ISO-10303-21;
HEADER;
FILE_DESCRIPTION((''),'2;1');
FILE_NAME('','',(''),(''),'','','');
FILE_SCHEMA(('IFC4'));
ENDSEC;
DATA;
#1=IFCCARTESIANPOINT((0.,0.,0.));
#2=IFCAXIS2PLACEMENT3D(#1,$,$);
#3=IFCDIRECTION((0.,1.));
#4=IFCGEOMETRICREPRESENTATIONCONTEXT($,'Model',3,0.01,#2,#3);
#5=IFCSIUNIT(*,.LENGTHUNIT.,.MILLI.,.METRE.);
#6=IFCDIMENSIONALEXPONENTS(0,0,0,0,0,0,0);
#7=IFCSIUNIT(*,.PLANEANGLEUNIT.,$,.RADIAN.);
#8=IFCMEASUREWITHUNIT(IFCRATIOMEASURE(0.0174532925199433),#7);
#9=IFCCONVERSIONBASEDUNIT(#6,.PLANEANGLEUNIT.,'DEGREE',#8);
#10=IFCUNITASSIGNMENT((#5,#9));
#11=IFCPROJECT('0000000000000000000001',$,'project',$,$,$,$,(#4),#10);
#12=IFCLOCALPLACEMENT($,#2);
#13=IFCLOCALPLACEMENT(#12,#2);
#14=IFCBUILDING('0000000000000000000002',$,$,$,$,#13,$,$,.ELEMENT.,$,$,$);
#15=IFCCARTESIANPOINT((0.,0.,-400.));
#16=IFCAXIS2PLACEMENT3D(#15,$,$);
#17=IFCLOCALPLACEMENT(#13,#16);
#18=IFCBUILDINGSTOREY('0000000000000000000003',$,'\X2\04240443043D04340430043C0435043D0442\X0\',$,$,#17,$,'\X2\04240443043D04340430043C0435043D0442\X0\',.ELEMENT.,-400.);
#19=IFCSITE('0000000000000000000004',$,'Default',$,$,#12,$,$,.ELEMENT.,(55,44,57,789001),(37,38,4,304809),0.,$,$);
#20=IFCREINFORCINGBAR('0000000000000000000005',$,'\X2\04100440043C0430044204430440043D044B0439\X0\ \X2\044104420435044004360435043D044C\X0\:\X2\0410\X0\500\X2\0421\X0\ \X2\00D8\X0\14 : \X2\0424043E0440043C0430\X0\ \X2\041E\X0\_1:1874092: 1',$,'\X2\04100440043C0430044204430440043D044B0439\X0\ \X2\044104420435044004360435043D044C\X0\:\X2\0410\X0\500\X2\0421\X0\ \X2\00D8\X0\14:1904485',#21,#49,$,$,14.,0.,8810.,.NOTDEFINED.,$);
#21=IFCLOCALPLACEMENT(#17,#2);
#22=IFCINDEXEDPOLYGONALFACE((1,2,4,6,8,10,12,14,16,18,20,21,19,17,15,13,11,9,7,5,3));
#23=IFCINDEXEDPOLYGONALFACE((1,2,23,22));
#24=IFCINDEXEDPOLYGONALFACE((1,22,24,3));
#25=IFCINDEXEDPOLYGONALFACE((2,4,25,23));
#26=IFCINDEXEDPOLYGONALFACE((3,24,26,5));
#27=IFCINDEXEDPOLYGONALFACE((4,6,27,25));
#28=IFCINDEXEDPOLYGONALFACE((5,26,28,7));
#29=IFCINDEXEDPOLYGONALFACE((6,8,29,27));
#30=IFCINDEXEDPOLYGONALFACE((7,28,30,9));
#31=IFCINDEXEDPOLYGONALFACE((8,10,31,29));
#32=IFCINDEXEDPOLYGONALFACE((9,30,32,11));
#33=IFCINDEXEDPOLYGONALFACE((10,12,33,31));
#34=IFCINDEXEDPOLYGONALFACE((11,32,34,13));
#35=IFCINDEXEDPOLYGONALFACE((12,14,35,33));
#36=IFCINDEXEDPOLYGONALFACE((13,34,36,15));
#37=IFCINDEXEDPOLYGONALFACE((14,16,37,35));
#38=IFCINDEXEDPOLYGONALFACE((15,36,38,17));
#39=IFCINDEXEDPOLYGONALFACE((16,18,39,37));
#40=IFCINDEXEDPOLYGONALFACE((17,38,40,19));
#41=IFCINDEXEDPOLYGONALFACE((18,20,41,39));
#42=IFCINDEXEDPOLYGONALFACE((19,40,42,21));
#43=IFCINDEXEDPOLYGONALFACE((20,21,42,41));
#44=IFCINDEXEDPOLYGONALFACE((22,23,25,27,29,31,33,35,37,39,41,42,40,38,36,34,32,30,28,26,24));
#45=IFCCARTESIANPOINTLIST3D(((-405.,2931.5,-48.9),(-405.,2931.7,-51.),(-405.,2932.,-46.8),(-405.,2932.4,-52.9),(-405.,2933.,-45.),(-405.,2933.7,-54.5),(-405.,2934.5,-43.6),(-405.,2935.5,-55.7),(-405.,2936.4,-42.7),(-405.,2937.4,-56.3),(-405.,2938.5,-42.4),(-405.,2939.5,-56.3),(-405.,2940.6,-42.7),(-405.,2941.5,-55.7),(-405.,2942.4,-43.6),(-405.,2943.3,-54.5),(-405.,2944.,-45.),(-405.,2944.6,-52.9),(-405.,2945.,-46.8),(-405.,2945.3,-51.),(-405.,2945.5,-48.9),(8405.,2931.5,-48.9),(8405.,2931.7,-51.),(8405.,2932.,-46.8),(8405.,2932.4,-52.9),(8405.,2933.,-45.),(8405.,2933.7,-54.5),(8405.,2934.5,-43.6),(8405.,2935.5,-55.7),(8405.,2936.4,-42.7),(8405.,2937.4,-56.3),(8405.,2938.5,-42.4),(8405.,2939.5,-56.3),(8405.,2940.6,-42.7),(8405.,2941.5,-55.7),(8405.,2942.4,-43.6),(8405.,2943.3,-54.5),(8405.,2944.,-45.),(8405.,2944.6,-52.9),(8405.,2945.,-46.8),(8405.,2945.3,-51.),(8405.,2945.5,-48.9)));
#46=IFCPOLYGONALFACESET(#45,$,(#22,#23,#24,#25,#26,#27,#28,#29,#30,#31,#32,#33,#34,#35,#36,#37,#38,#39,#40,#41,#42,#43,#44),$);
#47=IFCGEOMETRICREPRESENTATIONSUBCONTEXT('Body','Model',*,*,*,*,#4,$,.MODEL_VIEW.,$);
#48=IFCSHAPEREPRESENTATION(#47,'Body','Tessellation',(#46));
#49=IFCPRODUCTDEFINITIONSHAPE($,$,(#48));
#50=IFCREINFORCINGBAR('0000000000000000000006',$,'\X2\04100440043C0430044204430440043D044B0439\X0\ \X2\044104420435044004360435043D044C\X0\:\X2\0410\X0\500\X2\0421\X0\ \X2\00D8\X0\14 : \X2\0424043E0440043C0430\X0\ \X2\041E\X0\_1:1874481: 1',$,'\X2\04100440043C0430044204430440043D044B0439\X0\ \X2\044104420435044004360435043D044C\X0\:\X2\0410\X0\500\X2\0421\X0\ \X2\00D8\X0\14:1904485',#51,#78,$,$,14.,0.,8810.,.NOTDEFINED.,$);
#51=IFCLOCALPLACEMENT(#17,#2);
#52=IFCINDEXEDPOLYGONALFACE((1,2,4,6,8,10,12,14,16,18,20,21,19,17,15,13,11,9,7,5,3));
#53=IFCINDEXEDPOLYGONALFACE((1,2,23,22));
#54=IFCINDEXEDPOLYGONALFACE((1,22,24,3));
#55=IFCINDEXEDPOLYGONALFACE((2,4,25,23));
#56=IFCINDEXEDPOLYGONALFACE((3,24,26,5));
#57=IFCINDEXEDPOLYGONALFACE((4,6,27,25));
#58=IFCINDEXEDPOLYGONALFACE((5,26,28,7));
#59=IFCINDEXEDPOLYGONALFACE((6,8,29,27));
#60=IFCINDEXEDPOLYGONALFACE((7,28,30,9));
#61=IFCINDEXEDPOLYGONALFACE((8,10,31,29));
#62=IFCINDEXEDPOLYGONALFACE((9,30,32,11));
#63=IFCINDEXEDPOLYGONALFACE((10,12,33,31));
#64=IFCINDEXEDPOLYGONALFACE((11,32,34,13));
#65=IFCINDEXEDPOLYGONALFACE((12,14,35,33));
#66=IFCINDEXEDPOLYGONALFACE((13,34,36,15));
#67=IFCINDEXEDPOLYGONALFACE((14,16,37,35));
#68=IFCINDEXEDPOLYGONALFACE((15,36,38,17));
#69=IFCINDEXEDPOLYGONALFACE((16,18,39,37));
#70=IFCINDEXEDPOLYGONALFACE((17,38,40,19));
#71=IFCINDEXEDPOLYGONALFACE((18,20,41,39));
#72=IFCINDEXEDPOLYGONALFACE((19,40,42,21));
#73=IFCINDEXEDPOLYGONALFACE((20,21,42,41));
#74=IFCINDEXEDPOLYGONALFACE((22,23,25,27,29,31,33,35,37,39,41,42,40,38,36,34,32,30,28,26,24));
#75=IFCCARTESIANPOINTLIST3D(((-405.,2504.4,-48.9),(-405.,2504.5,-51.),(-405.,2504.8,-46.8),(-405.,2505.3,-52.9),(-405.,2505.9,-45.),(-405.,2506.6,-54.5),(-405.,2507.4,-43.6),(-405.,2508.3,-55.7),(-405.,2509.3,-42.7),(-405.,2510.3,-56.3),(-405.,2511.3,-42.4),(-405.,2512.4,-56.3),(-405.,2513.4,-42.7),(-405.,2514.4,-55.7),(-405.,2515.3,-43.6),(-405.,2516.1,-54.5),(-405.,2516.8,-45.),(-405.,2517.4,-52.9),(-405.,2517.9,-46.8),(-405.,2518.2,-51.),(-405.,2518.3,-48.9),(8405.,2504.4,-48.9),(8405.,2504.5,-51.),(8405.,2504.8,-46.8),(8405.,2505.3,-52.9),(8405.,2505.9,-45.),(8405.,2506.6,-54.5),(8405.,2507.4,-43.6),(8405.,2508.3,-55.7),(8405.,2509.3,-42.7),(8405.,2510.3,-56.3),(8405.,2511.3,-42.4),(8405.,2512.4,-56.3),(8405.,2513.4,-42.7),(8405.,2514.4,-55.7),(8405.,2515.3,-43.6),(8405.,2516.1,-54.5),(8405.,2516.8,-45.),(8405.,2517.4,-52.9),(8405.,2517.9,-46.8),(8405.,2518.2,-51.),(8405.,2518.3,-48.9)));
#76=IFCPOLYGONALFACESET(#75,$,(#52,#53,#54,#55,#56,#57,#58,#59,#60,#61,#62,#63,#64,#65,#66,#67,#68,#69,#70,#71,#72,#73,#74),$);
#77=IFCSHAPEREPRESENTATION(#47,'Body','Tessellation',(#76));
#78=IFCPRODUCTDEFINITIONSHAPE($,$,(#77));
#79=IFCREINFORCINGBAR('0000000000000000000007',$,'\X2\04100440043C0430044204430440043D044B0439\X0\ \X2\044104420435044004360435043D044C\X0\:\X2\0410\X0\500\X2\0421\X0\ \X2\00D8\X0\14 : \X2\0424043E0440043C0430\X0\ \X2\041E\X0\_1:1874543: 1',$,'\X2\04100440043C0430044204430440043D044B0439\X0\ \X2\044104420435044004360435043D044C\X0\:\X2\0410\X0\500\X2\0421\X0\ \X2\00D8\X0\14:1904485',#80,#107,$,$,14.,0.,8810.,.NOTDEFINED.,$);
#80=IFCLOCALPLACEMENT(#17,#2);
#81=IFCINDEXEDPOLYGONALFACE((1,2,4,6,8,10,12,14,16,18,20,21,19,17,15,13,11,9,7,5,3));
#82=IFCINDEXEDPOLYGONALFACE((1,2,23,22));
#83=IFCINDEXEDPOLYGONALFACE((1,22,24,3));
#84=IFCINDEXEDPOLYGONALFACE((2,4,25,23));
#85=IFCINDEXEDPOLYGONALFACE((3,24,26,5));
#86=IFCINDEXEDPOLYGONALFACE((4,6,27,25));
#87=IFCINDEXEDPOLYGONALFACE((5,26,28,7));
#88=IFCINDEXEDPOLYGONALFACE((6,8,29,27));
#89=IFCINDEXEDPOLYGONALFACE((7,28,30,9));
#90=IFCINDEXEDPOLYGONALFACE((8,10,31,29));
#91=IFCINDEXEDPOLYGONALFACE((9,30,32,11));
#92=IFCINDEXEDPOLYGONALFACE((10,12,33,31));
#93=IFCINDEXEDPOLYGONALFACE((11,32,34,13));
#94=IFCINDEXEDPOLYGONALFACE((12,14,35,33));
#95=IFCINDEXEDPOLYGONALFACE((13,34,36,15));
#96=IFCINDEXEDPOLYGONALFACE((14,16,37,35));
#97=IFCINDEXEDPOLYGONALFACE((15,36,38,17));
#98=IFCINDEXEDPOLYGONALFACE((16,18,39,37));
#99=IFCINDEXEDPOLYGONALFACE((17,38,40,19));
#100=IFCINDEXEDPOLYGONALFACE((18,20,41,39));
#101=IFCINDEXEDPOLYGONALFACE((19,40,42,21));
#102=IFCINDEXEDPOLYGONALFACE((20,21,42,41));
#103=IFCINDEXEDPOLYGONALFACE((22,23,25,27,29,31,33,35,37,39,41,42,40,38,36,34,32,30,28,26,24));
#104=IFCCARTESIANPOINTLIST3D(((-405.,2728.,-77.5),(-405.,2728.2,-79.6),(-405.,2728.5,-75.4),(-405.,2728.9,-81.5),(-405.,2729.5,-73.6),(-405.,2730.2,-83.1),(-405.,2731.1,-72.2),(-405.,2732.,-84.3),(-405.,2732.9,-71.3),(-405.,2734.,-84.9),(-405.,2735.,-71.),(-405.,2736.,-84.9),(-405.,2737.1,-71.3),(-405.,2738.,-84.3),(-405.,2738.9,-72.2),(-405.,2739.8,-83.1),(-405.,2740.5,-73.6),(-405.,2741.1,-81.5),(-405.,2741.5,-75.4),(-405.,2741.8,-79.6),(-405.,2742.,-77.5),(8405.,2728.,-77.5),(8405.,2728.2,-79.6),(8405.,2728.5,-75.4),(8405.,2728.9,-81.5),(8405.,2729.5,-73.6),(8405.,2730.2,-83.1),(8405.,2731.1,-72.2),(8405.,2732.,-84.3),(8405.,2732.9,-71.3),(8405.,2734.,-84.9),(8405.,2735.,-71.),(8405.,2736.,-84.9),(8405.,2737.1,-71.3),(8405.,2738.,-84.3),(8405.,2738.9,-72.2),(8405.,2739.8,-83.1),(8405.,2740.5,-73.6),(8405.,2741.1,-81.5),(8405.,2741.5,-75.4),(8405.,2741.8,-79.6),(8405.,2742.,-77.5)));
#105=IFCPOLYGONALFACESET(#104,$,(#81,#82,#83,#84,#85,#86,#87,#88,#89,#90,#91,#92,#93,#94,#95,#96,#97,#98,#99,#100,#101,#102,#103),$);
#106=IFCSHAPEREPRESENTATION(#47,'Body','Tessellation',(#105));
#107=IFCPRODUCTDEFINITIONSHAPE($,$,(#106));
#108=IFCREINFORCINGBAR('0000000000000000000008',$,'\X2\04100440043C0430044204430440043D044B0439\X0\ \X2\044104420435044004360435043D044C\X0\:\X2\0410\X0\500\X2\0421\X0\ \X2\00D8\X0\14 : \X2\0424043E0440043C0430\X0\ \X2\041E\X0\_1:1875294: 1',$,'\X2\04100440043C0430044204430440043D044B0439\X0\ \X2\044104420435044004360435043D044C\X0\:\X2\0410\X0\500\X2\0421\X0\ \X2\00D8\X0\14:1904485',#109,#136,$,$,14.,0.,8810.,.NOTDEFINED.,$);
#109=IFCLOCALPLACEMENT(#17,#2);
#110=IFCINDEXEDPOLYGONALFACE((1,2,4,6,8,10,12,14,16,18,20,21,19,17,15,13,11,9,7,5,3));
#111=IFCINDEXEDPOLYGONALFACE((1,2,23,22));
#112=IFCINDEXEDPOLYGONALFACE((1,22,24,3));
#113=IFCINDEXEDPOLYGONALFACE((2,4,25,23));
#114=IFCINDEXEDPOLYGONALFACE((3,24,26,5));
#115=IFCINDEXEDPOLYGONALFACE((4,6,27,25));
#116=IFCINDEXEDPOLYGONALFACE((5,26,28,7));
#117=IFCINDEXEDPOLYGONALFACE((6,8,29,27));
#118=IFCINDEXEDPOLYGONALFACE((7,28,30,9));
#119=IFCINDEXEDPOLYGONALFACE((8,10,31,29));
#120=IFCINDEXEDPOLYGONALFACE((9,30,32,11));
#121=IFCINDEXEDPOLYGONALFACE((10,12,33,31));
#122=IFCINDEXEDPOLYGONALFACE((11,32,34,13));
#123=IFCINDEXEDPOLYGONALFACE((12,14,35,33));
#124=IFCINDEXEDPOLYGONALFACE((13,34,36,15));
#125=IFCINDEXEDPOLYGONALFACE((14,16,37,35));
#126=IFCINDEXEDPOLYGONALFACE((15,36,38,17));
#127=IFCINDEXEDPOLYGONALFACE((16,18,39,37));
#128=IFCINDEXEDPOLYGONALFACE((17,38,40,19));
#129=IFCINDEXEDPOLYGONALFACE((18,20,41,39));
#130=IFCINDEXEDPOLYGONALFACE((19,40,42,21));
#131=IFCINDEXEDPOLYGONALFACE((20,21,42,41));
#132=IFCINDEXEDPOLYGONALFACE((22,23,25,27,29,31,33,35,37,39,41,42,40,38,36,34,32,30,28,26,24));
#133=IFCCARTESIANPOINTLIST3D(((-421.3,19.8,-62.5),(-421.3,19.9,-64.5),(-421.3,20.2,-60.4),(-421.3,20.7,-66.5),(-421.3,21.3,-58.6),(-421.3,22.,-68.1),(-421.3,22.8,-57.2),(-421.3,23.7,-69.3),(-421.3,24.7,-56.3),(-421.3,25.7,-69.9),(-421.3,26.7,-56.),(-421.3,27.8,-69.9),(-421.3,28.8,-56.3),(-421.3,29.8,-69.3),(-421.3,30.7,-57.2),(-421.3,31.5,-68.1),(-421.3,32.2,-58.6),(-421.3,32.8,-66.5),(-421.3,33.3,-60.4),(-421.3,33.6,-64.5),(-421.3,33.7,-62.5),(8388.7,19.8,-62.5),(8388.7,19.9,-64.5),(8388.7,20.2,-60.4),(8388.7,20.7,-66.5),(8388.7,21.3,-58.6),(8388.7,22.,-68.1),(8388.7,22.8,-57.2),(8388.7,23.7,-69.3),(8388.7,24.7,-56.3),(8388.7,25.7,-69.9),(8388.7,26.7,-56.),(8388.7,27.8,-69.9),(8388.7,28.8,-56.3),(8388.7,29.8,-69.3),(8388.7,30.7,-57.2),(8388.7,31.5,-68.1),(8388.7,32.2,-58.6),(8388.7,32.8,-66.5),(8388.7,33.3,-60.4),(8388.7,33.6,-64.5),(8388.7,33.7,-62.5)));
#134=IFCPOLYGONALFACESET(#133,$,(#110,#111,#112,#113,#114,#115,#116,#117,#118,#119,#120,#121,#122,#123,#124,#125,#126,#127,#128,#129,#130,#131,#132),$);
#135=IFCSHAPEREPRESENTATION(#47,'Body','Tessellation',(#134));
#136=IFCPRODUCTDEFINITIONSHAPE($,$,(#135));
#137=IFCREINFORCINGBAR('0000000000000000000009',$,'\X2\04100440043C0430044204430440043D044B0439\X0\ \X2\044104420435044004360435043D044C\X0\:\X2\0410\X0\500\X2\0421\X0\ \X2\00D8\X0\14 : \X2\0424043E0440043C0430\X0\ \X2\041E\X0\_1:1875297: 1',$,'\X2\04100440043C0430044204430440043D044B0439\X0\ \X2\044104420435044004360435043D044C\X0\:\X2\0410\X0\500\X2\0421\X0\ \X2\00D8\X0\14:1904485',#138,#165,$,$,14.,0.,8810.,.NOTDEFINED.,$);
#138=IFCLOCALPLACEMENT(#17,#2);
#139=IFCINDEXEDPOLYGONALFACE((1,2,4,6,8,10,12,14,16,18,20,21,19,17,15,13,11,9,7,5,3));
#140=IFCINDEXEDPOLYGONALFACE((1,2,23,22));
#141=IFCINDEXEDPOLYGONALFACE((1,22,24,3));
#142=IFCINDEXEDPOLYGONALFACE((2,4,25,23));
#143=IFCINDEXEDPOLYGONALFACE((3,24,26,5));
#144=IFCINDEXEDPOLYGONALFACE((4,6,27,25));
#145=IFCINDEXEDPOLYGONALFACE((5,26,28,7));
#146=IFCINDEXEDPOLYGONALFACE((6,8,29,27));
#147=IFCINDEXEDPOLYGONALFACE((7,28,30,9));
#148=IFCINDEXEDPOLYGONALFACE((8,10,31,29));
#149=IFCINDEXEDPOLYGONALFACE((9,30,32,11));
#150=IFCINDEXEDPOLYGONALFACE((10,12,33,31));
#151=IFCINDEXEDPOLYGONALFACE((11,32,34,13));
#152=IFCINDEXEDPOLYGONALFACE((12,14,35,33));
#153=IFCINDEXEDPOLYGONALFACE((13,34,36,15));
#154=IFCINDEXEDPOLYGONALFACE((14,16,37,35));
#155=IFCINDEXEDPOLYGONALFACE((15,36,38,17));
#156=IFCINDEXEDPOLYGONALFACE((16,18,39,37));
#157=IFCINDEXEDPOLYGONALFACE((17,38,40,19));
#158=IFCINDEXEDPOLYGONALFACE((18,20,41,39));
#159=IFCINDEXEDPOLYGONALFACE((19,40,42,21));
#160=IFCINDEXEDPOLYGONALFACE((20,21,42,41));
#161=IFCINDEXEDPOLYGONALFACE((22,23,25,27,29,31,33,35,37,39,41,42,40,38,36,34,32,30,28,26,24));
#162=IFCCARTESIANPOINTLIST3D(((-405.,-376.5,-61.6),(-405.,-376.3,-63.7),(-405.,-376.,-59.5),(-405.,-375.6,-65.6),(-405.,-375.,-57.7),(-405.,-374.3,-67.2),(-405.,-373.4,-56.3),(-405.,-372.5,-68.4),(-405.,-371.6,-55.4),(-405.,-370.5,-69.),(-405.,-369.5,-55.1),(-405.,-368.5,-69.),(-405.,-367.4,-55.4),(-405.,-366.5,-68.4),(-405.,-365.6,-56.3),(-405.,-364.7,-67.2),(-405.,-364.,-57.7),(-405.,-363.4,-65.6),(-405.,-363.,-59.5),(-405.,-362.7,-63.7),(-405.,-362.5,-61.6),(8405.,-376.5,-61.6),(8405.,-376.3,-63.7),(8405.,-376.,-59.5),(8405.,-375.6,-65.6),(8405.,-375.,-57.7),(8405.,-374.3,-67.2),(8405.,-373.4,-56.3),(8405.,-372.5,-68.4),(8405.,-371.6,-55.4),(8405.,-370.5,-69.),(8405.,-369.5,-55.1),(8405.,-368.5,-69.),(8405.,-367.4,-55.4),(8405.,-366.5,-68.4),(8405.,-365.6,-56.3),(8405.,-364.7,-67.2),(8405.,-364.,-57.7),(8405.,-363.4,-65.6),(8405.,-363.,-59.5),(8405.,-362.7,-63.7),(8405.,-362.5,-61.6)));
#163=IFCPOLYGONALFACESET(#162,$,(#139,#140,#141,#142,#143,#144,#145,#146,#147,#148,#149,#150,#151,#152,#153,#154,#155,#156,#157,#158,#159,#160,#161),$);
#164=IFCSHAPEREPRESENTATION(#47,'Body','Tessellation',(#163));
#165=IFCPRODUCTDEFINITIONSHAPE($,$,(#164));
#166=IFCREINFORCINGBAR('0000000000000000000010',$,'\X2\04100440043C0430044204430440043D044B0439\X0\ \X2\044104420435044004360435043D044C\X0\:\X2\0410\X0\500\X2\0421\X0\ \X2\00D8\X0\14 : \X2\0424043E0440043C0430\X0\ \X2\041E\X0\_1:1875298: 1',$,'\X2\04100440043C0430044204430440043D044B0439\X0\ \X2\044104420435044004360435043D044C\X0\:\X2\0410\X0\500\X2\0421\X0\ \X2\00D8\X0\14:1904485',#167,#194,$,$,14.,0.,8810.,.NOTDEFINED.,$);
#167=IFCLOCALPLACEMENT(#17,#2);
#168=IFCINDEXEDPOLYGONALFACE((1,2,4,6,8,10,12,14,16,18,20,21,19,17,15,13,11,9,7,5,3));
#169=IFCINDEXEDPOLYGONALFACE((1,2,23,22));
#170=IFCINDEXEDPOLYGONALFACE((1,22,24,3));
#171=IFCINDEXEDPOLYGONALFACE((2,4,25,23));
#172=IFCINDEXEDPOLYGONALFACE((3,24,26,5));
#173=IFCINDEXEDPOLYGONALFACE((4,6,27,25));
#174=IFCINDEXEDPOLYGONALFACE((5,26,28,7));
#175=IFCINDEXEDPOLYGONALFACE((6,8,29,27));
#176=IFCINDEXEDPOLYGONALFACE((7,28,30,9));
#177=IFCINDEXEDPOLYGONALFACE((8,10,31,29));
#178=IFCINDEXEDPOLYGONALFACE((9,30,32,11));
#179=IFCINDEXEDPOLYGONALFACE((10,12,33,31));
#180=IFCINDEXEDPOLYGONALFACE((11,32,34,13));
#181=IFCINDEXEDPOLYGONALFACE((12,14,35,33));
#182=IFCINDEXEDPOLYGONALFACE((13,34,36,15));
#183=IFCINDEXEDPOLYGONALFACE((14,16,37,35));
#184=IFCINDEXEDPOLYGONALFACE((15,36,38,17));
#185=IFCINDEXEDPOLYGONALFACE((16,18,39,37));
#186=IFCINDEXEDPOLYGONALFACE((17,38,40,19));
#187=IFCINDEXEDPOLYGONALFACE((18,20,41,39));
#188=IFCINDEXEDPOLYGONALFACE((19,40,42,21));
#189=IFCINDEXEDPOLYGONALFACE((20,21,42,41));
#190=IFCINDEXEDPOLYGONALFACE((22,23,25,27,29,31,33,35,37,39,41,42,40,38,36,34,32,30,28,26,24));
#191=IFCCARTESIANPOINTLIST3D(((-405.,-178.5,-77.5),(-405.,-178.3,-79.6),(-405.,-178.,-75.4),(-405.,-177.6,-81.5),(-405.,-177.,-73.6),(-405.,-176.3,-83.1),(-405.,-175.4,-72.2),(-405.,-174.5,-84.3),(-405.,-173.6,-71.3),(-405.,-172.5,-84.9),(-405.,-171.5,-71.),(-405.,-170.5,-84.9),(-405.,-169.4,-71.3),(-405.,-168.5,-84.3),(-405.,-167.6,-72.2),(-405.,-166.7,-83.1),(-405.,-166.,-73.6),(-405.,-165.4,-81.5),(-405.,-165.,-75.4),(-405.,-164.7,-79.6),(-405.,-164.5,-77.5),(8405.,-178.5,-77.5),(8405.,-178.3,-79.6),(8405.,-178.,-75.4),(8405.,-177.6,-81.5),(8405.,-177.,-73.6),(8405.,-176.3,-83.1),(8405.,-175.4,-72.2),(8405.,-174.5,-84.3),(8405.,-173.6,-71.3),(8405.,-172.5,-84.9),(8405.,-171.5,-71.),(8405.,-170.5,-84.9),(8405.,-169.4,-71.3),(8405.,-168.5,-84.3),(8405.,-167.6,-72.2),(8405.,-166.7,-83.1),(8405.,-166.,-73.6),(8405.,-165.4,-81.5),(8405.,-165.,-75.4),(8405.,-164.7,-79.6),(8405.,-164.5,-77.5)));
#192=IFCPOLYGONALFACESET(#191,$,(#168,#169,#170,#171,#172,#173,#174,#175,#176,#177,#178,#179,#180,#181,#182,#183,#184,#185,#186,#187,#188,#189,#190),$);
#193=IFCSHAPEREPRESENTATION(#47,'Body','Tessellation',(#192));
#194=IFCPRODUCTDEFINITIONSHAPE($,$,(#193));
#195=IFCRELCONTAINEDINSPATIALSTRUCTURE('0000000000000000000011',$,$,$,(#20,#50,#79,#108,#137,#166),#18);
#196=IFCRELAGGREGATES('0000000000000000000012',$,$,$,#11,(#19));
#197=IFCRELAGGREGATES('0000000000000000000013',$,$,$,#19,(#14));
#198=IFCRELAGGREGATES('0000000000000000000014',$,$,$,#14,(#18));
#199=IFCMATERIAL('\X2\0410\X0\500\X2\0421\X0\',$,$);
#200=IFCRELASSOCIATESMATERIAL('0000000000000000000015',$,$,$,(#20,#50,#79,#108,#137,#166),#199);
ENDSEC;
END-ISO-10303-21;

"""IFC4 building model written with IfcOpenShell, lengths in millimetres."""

from ifc_helpers import new_model, entity, si_unit, converted_unit, direction, frame, origin, place, context, subcontext, project, spatial, material, element, save


model = new_model("IFC4")

# Units and contexts
model_context = context("Model", 3, precision=0.01, world=origin(), true_north=direction((0.0, 1.0)))
body_context = subcontext(model_context, "Body", "Model", "MODEL_VIEW")
ifc_project = project(units=[si_unit("LENGTHUNIT", "METRE", prefix="MILLI"), converted_unit("PLANEANGLEUNIT", "DEGREE", entity("IfcRatioMeasure", 0.0174532925199433), si_unit("PLANEANGLEUNIT", "RADIAN"), dimensions=[0, 0, 0, 0, 0, 0, 0])], contexts=[model_context])

# Site, building, storey
site_placement = place(None, origin())
site = spatial("IfcSite", under=ifc_project, at=site_placement, Name="Default", CompositionType="ELEMENT", RefLatitude=(55, 44, 57, 789001), RefLongitude=(37, 38, 4, 304809), RefElevation=0.0)
building_placement = place(site_placement, origin())
building = spatial("IfcBuilding", under=site, at=building_placement, CompositionType="ELEMENT")
storey_placement = place(building_placement, frame((0.0, 0.0, -400.0)))
storey = spatial("IfcBuildingStorey", under=building, at=storey_placement, Name="Фундамент", LongName="Фундамент", CompositionType="ELEMENT", Elevation=-400.0)

# Reinforcing bars
ifc_material = material(Name="А500С")
reinforcing_bar_1_placement = place(storey_placement, origin())
element("IfcReinforcingBar", 1, at=reinforcing_bar_1_placement, inside=storey, material=ifc_material, Name="Арматурный стержень:А500С Ø14 : Форма О_1:1874092: 1", ObjectType="Арматурный стержень:А500С Ø14:1904485", BarLength=8810.0, CrossSectionArea=0.0, NominalDiameter=14.0, PredefinedType="NOTDEFINED", context=body_context, shape_type="AdvancedSweptSolid", body=[
    entity("IfcSweptDiskSolid", entity("IfcCompositeCurve", [entity("IfcCompositeCurveSegment", "CONTINUOUS", True, entity("IfcPolyline", [entity("IfcCartesianPoint", [-405.0, 2938.5, -49.4]), entity("IfcCartesianPoint", [8405.0, 2938.5, -49.4])]))], False), 7.0, None, 0.0, 1.0),
])
reinforcing_bar_2_placement = place(storey_placement, origin())
element("IfcReinforcingBar", 2, at=reinforcing_bar_2_placement, inside=storey, material=ifc_material, Name="Арматурный стержень:А500С Ø14 : Форма О_1:1874481: 1", ObjectType="Арматурный стержень:А500С Ø14:1904485", BarLength=8810.0, CrossSectionArea=0.0, NominalDiameter=14.0, PredefinedType="NOTDEFINED", context=body_context, shape_type="AdvancedSweptSolid", body=[
    entity("IfcSweptDiskSolid", entity("IfcCompositeCurve", [entity("IfcCompositeCurveSegment", "CONTINUOUS", True, entity("IfcPolyline", [entity("IfcCartesianPoint", [-405.0, 2511.3, -49.4]), entity("IfcCartesianPoint", [8405.0, 2511.3, -49.4])]))], False), 7.0, None, 0.0, 1.0),
])
reinforcing_bar_3_placement = place(storey_placement, origin())
element("IfcReinforcingBar", 3, at=reinforcing_bar_3_placement, inside=storey, material=ifc_material, Name="Арматурный стержень:А500С Ø14 : Форма О_1:1874543: 1", ObjectType="Арматурный стержень:А500С Ø14:1904485", BarLength=8810.0, CrossSectionArea=0.0, NominalDiameter=14.0, PredefinedType="NOTDEFINED", context=body_context, shape_type="AdvancedSweptSolid", body=[
    entity("IfcSweptDiskSolid", entity("IfcCompositeCurve", [entity("IfcCompositeCurveSegment", "CONTINUOUS", True, entity("IfcPolyline", [entity("IfcCartesianPoint", [-405.0, 2735.0, -78.0]), entity("IfcCartesianPoint", [8405.0, 2735.0, -78.0])]))], False), 7.0, None, 0.0, 1.0),
])
reinforcing_bar_4_placement = place(storey_placement, origin())
element("IfcReinforcingBar", 4, at=reinforcing_bar_4_placement, inside=storey, material=ifc_material, Name="Арматурный стержень:А500С Ø14 : Форма О_1:1875294: 1", ObjectType="Арматурный стержень:А500С Ø14:1904485", BarLength=8810.0, CrossSectionArea=0.0, NominalDiameter=14.0, PredefinedType="NOTDEFINED", context=body_context, shape_type="AdvancedSweptSolid", body=[
    entity("IfcSweptDiskSolid", entity("IfcCompositeCurve", [entity("IfcCompositeCurveSegment", "CONTINUOUS", True, entity("IfcPolyline", [entity("IfcCartesianPoint", [-421.3, 26.7, -63.0]), entity("IfcCartesianPoint", [8388.7, 26.7, -63.0])]))], False), 7.0, None, 0.0, 1.0),
])
reinforcing_bar_5_placement = place(storey_placement, origin())
element("IfcReinforcingBar", 5, at=reinforcing_bar_5_placement, inside=storey, material=ifc_material, Name="Арматурный стержень:А500С Ø14 : Форма О_1:1875297: 1", ObjectType="Арматурный стержень:А500С Ø14:1904485", BarLength=8810.0, CrossSectionArea=0.0, NominalDiameter=14.0, PredefinedType="NOTDEFINED", context=body_context, shape_type="AdvancedSweptSolid", body=[
    entity("IfcSweptDiskSolid", entity("IfcCompositeCurve", [entity("IfcCompositeCurveSegment", "CONTINUOUS", True, entity("IfcPolyline", [entity("IfcCartesianPoint", [-405.0, -369.5, -62.1]), entity("IfcCartesianPoint", [8405.0, -369.5, -62.1])]))], False), 7.0, None, 0.0, 1.0),
])
reinforcing_bar_6_placement = place(storey_placement, origin())
element("IfcReinforcingBar", 6, at=reinforcing_bar_6_placement, inside=storey, material=ifc_material, Name="Арматурный стержень:А500С Ø14 : Форма О_1:1875298: 1", ObjectType="Арматурный стержень:А500С Ø14:1904485", BarLength=8810.0, CrossSectionArea=0.0, NominalDiameter=14.0, PredefinedType="NOTDEFINED", context=body_context, shape_type="AdvancedSweptSolid", body=[
    entity("IfcSweptDiskSolid", entity("IfcCompositeCurve", [entity("IfcCompositeCurveSegment", "CONTINUOUS", True, entity("IfcPolyline", [entity("IfcCartesianPoint", [-405.0, -171.5, -78.0]), entity("IfcCartesianPoint", [8405.0, -171.5, -78.0])]))], False), 7.0, None, 0.0, 1.0),
])

save(model, "model.ifc")
